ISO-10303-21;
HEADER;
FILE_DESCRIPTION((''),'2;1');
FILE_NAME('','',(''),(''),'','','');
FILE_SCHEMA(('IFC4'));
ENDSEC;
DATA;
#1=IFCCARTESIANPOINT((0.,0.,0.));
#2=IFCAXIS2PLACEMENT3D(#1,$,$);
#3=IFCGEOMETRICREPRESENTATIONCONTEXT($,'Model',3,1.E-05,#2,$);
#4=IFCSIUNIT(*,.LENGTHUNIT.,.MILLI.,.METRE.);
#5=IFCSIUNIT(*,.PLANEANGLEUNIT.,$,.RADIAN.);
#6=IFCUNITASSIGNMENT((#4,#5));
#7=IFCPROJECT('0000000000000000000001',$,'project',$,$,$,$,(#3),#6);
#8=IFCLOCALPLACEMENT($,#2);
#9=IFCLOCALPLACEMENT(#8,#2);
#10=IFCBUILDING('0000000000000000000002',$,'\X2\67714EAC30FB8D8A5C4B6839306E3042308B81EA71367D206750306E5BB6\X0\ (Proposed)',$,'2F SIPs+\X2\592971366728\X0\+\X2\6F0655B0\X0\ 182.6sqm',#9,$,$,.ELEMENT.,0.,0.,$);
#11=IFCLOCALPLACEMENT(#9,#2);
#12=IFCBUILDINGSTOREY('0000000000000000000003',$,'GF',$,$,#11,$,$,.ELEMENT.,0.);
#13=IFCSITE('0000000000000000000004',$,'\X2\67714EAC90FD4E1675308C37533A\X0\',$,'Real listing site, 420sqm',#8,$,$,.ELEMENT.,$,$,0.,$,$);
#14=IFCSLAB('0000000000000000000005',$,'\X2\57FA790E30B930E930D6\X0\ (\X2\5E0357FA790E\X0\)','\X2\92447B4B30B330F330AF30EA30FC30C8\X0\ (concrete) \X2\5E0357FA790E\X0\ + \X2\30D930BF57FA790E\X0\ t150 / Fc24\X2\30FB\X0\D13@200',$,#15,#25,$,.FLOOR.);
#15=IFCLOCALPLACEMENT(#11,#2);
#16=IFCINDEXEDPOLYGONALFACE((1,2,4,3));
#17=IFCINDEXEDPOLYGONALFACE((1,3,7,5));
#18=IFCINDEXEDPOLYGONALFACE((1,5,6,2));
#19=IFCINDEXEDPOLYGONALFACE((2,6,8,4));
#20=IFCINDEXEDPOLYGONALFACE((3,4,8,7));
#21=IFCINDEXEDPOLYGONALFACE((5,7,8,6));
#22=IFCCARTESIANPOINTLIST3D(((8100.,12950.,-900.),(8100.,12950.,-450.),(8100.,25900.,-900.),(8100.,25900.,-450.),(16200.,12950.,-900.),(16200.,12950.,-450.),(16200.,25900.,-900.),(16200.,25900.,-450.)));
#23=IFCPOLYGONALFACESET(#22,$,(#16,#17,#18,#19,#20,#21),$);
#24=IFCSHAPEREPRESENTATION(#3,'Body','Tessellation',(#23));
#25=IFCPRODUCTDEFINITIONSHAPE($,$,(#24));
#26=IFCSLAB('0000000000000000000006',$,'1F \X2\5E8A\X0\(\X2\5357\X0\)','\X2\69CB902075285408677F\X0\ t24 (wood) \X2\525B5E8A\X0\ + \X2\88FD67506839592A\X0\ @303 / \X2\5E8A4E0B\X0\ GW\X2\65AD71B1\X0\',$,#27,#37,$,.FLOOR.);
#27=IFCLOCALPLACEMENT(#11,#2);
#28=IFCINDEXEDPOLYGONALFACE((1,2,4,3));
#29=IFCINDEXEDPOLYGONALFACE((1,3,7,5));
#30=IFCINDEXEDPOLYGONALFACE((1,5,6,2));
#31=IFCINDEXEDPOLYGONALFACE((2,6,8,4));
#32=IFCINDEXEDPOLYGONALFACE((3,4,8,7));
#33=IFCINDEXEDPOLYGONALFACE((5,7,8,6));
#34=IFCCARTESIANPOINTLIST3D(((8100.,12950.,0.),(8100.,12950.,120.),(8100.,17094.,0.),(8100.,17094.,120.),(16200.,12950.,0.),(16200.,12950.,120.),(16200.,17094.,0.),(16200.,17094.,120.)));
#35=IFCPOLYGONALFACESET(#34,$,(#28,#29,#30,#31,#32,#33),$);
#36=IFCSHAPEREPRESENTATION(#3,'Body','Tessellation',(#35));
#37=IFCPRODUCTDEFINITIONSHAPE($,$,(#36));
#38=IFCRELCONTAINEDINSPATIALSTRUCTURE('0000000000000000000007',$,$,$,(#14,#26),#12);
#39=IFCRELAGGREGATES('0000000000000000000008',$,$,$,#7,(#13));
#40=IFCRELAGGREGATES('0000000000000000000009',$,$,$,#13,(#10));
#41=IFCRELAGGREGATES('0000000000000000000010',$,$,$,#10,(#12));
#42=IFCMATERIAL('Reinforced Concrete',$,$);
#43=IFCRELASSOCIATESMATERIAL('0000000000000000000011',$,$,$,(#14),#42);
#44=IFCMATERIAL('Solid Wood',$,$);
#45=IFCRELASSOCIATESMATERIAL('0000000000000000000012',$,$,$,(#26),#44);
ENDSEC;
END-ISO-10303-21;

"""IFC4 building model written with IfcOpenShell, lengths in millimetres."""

from ifc_helpers import new_model, si_unit, frame, frame_2d, origin, place, context, project, spatial, rectangle, extrude, material, element, save


model = new_model("IFC4")

# Units and contexts
model_context = context("Model", 3, precision=1e-05, world=origin())
ifc_project = project(units=[si_unit("LENGTHUNIT", "METRE", prefix="MILLI"), si_unit("PLANEANGLEUNIT", "RADIAN")], contexts=[model_context])

# Site, building, storey
site_placement = place(None, origin())
site = spatial("IfcSite", under=ifc_project, at=site_placement, Name="東京都世田谷区", ObjectType="Real listing site, 420sqm", CompositionType="ELEMENT", RefElevation=0.0)
building_placement = place(site_placement, origin())
building = spatial("IfcBuilding", under=site, at=building_placement, Name="東京・越屋根のある自然素材の家 (Proposed)", ObjectType="2F SIPs+天然木+漆喰 182.6sqm", CompositionType="ELEMENT", ElevationOfRefHeight=0.0, ElevationOfTerrain=0.0)
storey_placement = place(building_placement, origin())
storey = spatial("IfcBuildingStorey", under=building, at=storey_placement, Name="GF", CompositionType="ELEMENT", Elevation=0.0)

# Shared definitions
ifc_material_1 = material(Name="Solid Wood")

# Slabs
ifc_material_2 = material(Name="Reinforced Concrete")
slab_1_placement = place(storey_placement, frame((4050.0, 6475.0, -450.0)))
element("IfcSlab", 1, at=slab_1_placement, inside=storey, material=ifc_material_2, Name="基礎スラブ (布基礎)", Description="鉄筋コンクリート (concrete) 布基礎 + ベタ基礎 t150 / Fc24・D13@200", PredefinedType="FLOOR", context=model_context, shape_type="SweptSolid", body=[
    extrude(rectangle(XDim=8100.0, YDim=12950.0, at=frame_2d((4050.0, 6475.0))), frame((4050.0, 6475.0, -450.0)), (0.0, 0.0, 1.0), 450.0),
])
slab_2_placement = place(storey_placement, frame((4050.0, 6475.0, 0.0)))
element("IfcSlab", 2, at=slab_2_placement, inside=storey, material=ifc_material_1, Name="1F 床(南)", Description="構造用合板 t24 (wood) 剛床 + 製材根太 @303 / 床下 GW断熱", PredefinedType="FLOOR", context=model_context, shape_type="SweptSolid", body=[
    extrude(rectangle(XDim=8100.0, YDim=4144.0, at=frame_2d((4050.0, 2072.0))), frame((4050.0, 6475.0, 0.0)), (0.0, 0.0, 1.0), 120.0),
])

save(model, "model.ifc")
